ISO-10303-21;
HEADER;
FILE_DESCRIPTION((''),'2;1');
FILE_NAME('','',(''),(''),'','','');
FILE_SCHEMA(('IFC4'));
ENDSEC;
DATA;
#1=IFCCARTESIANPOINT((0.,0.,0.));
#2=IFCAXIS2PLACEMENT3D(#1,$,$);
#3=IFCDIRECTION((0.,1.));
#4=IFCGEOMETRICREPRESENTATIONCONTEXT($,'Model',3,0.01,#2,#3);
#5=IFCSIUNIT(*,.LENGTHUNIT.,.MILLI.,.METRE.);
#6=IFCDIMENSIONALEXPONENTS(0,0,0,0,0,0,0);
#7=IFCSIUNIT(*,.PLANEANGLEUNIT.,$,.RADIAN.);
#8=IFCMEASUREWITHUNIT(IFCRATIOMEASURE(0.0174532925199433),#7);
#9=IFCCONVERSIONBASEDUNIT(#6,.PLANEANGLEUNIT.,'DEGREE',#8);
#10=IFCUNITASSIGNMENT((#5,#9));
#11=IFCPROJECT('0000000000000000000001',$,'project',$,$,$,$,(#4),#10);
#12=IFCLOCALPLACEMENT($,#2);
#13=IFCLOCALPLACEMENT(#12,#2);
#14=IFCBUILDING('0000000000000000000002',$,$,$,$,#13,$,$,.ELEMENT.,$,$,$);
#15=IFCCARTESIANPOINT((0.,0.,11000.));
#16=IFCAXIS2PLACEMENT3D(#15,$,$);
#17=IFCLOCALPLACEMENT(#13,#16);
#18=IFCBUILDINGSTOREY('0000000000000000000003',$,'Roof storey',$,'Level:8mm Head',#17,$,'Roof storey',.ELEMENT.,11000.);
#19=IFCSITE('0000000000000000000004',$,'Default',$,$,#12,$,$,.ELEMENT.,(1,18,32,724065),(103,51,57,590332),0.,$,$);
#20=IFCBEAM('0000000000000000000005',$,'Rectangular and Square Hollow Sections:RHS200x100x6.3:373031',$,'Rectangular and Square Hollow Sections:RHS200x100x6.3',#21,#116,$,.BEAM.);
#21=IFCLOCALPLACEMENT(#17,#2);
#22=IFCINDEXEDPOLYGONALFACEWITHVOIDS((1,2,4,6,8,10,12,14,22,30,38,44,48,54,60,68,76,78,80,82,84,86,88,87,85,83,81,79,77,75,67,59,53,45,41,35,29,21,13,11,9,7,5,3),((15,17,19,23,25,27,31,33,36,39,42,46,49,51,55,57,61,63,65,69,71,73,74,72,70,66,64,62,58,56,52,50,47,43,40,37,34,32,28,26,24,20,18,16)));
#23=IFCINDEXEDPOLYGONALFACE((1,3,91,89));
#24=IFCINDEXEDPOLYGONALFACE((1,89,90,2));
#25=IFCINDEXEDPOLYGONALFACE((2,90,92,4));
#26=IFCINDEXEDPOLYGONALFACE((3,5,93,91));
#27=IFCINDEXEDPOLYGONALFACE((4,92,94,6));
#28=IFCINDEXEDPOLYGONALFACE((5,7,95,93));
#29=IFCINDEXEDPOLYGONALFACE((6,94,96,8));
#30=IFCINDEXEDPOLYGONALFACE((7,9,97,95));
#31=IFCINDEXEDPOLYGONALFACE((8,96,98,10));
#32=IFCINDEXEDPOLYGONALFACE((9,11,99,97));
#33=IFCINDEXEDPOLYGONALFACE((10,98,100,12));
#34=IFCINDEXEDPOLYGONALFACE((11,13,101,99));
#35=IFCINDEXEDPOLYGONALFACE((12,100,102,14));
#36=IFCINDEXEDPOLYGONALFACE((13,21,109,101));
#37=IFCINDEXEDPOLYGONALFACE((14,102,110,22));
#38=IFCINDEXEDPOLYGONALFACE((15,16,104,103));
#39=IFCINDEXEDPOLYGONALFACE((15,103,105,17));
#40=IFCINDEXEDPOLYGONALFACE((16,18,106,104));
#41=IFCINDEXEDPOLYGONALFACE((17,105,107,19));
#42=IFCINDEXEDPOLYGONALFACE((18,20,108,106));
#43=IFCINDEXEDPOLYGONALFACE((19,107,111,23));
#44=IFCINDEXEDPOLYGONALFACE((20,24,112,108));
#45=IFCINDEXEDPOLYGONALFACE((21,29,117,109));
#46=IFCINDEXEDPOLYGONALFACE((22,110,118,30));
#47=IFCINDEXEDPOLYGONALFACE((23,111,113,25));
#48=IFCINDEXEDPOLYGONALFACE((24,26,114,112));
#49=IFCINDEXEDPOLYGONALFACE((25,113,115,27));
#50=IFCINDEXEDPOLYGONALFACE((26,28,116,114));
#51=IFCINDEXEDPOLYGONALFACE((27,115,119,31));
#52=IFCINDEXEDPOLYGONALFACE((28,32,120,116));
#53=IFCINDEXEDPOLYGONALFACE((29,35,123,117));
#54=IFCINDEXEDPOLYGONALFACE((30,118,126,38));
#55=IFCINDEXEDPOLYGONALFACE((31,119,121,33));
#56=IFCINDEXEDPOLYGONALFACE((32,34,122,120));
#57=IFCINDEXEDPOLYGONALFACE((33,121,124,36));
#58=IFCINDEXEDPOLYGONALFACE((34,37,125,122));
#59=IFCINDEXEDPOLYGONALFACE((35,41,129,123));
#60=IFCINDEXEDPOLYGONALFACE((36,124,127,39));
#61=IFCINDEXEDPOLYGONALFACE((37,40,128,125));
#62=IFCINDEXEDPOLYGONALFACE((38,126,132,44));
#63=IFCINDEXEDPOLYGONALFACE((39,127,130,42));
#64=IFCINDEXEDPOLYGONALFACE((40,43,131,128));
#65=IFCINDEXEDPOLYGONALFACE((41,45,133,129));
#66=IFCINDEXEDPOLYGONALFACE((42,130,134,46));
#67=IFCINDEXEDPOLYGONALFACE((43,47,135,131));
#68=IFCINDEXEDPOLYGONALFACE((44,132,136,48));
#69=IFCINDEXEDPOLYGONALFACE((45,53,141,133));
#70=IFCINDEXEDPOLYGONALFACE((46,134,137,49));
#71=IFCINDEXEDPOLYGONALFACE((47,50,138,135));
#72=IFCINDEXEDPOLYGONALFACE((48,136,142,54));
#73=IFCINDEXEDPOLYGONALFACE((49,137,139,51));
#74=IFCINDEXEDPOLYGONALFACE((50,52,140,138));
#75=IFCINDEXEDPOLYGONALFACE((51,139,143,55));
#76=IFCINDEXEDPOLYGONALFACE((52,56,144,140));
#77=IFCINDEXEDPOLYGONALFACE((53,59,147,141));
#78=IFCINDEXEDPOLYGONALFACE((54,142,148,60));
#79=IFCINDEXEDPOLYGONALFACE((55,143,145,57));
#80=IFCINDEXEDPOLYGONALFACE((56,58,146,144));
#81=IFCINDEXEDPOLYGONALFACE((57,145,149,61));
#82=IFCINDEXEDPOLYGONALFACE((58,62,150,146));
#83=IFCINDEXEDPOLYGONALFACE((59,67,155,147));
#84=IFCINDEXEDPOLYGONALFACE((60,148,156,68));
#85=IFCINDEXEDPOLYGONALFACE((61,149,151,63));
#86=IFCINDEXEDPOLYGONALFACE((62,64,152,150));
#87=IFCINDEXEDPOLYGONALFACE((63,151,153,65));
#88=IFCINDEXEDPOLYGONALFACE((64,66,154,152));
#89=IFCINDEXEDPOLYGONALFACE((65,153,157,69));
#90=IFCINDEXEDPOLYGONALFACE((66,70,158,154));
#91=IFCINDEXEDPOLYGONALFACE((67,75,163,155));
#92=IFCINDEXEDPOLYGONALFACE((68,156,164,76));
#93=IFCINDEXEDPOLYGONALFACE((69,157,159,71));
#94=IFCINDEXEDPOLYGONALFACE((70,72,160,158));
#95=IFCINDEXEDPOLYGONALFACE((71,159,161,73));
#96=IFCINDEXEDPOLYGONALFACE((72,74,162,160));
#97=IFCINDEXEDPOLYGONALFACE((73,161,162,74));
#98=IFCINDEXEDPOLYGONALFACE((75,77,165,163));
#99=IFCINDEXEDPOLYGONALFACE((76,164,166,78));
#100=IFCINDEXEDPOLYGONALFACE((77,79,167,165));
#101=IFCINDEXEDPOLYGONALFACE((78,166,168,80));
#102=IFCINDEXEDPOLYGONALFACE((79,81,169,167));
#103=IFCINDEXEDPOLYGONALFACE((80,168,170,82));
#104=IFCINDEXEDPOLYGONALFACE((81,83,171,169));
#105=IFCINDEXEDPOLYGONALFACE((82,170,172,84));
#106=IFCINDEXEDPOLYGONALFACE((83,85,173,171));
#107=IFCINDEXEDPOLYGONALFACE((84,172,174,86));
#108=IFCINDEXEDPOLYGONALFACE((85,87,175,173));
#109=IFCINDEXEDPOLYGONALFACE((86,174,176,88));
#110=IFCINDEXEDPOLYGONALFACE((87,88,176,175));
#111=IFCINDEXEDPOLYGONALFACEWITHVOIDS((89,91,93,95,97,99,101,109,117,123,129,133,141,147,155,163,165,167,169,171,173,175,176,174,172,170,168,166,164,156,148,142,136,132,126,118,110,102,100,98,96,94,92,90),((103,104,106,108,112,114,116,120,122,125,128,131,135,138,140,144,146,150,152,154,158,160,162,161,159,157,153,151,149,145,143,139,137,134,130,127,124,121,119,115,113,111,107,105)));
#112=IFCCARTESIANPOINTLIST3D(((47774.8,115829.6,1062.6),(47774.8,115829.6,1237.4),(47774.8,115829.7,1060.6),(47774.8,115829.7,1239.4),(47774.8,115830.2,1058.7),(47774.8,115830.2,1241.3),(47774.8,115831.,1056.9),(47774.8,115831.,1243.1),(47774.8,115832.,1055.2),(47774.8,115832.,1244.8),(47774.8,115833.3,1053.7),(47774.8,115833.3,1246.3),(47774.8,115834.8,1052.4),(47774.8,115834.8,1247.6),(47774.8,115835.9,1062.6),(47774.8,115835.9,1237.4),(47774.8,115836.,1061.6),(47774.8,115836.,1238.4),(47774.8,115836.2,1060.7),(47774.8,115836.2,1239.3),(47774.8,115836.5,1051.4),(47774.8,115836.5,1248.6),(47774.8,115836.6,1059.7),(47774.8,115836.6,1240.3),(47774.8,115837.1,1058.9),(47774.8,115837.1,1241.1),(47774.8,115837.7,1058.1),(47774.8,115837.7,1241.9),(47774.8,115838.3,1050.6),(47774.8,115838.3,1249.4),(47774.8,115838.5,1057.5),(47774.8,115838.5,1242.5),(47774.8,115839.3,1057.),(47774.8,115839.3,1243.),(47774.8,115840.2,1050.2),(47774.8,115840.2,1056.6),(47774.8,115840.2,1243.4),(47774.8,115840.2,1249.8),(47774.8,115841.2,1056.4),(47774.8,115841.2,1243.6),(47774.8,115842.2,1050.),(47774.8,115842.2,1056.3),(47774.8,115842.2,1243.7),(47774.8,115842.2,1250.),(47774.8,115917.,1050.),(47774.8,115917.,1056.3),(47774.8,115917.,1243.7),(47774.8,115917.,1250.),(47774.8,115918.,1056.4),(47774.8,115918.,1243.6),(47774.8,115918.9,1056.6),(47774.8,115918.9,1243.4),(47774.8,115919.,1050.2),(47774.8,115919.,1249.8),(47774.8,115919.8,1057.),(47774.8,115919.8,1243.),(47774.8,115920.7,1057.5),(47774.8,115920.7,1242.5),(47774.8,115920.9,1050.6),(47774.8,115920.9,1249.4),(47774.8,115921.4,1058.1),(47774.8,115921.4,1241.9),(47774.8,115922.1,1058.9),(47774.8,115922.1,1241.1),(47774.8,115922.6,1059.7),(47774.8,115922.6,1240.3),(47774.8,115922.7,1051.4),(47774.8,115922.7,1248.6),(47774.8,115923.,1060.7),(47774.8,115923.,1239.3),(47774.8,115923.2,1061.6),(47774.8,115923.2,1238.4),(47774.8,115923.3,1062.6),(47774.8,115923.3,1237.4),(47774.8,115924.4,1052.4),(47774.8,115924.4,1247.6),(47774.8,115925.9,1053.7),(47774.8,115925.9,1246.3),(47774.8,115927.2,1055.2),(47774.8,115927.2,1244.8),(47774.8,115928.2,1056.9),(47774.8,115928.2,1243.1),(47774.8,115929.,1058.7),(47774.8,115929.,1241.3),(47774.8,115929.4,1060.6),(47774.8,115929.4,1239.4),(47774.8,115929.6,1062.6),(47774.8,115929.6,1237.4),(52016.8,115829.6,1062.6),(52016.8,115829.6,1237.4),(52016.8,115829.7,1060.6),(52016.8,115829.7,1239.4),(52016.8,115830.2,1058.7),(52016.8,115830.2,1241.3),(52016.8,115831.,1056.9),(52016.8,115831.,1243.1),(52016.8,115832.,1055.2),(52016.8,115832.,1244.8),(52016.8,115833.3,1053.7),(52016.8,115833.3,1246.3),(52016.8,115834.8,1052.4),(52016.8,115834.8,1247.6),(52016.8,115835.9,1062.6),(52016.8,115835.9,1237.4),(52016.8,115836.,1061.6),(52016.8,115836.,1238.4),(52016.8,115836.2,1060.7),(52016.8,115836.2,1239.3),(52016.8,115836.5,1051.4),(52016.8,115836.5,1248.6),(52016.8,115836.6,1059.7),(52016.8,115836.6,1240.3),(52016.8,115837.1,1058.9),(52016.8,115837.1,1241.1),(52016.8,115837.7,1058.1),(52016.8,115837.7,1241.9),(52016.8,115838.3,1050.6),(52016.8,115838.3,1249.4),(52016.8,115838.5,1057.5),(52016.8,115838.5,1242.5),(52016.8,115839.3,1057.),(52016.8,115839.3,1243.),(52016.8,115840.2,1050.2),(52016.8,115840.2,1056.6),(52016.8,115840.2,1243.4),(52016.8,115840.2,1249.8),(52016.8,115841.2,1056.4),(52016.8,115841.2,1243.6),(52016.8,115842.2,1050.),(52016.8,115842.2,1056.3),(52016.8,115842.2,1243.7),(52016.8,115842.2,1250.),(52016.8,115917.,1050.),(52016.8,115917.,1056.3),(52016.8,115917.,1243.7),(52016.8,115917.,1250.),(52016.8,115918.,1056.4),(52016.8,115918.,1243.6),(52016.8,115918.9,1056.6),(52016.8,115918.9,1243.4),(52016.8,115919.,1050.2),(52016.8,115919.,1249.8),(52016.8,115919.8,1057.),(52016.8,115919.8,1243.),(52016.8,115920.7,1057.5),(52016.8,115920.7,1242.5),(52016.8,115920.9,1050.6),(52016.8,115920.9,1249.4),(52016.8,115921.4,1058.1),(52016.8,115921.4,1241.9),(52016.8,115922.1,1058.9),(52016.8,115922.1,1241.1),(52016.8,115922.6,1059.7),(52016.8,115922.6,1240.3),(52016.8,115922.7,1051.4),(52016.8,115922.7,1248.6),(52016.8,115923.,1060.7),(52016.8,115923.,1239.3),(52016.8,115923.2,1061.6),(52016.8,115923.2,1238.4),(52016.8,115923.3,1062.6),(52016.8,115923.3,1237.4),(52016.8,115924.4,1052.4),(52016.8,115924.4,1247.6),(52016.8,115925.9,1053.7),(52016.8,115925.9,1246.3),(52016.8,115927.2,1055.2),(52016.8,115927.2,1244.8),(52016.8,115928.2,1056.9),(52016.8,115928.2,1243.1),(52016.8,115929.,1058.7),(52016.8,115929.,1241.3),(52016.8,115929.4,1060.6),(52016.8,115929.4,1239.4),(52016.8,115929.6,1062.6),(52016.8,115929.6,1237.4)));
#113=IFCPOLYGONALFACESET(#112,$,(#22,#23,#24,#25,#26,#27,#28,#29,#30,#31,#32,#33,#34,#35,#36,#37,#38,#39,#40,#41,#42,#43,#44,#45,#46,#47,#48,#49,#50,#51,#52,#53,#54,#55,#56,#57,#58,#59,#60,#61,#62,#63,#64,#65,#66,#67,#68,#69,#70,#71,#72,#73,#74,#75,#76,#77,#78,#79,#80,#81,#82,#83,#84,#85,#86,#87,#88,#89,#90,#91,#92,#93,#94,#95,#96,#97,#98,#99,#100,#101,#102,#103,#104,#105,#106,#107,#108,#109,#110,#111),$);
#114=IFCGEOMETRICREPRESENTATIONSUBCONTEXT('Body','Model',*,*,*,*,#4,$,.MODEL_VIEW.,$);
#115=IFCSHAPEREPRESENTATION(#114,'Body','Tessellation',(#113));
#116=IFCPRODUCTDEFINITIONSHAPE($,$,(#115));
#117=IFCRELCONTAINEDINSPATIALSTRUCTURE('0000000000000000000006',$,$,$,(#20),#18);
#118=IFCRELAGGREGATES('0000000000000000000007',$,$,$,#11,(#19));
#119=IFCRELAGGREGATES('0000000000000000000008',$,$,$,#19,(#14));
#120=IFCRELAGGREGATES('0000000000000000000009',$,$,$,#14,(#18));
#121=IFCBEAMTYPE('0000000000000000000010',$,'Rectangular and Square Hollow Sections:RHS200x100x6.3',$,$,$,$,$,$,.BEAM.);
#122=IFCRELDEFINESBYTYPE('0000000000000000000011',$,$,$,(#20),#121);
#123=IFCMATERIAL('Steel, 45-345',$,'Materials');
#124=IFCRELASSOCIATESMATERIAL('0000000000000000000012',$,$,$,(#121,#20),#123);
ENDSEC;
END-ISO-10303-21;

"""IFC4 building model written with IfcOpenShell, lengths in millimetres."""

from ifc_helpers import new_model, entity, si_unit, converted_unit, direction, frame, origin, place, context, subcontext, project, spatial, indexed_curve, outline, extrude, source, transform, mapped, material, type_object, type_shapes, element, save


model = new_model("IFC4")

# Units and contexts
model_context = context("Model", 3, precision=0.01, world=origin(), true_north=direction((0.0, 1.0)))
body_context = subcontext(model_context, "Body", "Model", "MODEL_VIEW")
ifc_project = project(units=[si_unit("LENGTHUNIT", "METRE", prefix="MILLI"), converted_unit("PLANEANGLEUNIT", "DEGREE", entity("IfcRatioMeasure", 0.0174532925199433), si_unit("PLANEANGLEUNIT", "RADIAN"), dimensions=[0, 0, 0, 0, 0, 0, 0])], contexts=[model_context])

# Site, building, storey
site_placement = place(None, origin())
site = spatial("IfcSite", under=ifc_project, at=site_placement, Name="Default", CompositionType="ELEMENT", RefLatitude=(1, 18, 32, 724065), RefLongitude=(103, 51, 57, 590332), RefElevation=0.0)
building_placement = place(site_placement, origin())
building = spatial("IfcBuilding", under=site, at=building_placement, CompositionType="ELEMENT")
storey_placement = place(building_placement, frame((0.0, 0.0, 11000.0)))
storey = spatial("IfcBuildingStorey", under=building, at=storey_placement, Name="Roof storey", ObjectType="Level:8mm Head", LongName="Roof storey", CompositionType="ELEMENT", Elevation=11000.0)

# Shared definitions
ifc_material = material(Name="Steel, 45-345", Category="Materials")

# Beam
beam_type_1 = type_object("IfcBeamType", Name="Rectangular and Square Hollow Sections:RHS200x100x6.3", PredefinedType="BEAM", material=ifc_material)
shared_shape_1 = source(origin(), body_context, "Body", "SweptSolid", [
    extrude(outline(indexed_curve([(-50.0, -87.4), (-49.8, -89.4), (-49.4, -91.3), (-48.6, -93.1), (-47.6, -94.8), (-46.3, -96.3), (-44.8, -97.6), (-43.1, -98.6), (-41.3, -99.4), (-39.4, -99.8), (-37.4, -100.0), (37.4, -100.0), (39.4, -99.8), (41.3, -99.4), (43.1, -98.6), (44.8, -97.6), (46.3, -96.3), (47.6, -94.8), (48.6, -93.1), (49.4, -91.3), (49.8, -89.4), (50.0, -87.4), (50.0, 87.4), (49.8, 89.4), (49.4, 91.3), (48.6, 93.1), (47.6, 94.8), (46.3, 96.3), (44.8, 97.6), (43.1, 98.6), (41.3, 99.4), (39.4, 99.8), (37.4, 100.0), (-37.4, 100.0), (-39.4, 99.8), (-41.3, 99.4), (-43.1, 98.6), (-44.8, 97.6), (-46.3, 96.3), (-47.6, 94.8), (-48.6, 93.1), (-49.4, 91.3), (-49.8, 89.4), (-50.0, 87.4), (-50.0, -87.4)], self_intersect=False), holes=[indexed_curve([(37.4, -93.7), (-37.4, -93.7), (-38.4, -93.6), (-39.3, -93.4), (-40.3, -93.0), (-41.1, -92.5), (-41.9, -91.9), (-42.5, -91.1), (-43.0, -90.3), (-43.4, -89.3), (-43.6, -88.4), (-43.7, -87.4), (-43.7, 87.4), (-43.6, 88.4), (-43.4, 89.3), (-43.0, 90.3), (-42.5, 91.1), (-41.9, 91.9), (-41.1, 92.5), (-40.3, 93.0), (-39.3, 93.4), (-38.4, 93.6), (-37.4, 93.7), (37.4, 93.7), (38.4, 93.6), (39.3, 93.4), (40.3, 93.0), (41.1, 92.5), (41.9, 91.9), (42.5, 91.1), (43.0, 90.3), (43.4, 89.3), (43.6, 88.4), (43.7, 87.4), (43.7, -87.4), (43.6, -88.4), (43.4, -89.3), (43.0, -90.3), (42.5, -91.1), (41.9, -91.9), (41.1, -92.5), (40.3, -93.0), (39.3, -93.4), (38.4, -93.6), (37.4, -93.7)], self_intersect=False)]), frame((-2114.5, 0.0, 0.0), z_axis=(1.0, 0.0, 0.0), x_axis=(0.0, -1.0, 0.0)), (0.0, 0.0, 1.0), 4242.0),
])
type_shapes(beam_type_1, [shared_shape_1])
beam_1_placement = place(storey_placement, frame((49889.3, 115879.6, 1150.0)))
element("IfcBeam", 1, at=beam_1_placement, inside=storey, type_object=beam_type_1, material=ifc_material, Name="Rectangular and Square Hollow Sections:RHS200x100x6.3:373031", ObjectType="Rectangular and Square Hollow Sections:RHS200x100x6.3", PredefinedType="BEAM", context=body_context, shape_type="MappedRepresentation", body=[
    mapped(shared_shape_1, transform((0.0, 0.0, 0.0), scale=1.0)),
])

save(model, "model.ifc")
